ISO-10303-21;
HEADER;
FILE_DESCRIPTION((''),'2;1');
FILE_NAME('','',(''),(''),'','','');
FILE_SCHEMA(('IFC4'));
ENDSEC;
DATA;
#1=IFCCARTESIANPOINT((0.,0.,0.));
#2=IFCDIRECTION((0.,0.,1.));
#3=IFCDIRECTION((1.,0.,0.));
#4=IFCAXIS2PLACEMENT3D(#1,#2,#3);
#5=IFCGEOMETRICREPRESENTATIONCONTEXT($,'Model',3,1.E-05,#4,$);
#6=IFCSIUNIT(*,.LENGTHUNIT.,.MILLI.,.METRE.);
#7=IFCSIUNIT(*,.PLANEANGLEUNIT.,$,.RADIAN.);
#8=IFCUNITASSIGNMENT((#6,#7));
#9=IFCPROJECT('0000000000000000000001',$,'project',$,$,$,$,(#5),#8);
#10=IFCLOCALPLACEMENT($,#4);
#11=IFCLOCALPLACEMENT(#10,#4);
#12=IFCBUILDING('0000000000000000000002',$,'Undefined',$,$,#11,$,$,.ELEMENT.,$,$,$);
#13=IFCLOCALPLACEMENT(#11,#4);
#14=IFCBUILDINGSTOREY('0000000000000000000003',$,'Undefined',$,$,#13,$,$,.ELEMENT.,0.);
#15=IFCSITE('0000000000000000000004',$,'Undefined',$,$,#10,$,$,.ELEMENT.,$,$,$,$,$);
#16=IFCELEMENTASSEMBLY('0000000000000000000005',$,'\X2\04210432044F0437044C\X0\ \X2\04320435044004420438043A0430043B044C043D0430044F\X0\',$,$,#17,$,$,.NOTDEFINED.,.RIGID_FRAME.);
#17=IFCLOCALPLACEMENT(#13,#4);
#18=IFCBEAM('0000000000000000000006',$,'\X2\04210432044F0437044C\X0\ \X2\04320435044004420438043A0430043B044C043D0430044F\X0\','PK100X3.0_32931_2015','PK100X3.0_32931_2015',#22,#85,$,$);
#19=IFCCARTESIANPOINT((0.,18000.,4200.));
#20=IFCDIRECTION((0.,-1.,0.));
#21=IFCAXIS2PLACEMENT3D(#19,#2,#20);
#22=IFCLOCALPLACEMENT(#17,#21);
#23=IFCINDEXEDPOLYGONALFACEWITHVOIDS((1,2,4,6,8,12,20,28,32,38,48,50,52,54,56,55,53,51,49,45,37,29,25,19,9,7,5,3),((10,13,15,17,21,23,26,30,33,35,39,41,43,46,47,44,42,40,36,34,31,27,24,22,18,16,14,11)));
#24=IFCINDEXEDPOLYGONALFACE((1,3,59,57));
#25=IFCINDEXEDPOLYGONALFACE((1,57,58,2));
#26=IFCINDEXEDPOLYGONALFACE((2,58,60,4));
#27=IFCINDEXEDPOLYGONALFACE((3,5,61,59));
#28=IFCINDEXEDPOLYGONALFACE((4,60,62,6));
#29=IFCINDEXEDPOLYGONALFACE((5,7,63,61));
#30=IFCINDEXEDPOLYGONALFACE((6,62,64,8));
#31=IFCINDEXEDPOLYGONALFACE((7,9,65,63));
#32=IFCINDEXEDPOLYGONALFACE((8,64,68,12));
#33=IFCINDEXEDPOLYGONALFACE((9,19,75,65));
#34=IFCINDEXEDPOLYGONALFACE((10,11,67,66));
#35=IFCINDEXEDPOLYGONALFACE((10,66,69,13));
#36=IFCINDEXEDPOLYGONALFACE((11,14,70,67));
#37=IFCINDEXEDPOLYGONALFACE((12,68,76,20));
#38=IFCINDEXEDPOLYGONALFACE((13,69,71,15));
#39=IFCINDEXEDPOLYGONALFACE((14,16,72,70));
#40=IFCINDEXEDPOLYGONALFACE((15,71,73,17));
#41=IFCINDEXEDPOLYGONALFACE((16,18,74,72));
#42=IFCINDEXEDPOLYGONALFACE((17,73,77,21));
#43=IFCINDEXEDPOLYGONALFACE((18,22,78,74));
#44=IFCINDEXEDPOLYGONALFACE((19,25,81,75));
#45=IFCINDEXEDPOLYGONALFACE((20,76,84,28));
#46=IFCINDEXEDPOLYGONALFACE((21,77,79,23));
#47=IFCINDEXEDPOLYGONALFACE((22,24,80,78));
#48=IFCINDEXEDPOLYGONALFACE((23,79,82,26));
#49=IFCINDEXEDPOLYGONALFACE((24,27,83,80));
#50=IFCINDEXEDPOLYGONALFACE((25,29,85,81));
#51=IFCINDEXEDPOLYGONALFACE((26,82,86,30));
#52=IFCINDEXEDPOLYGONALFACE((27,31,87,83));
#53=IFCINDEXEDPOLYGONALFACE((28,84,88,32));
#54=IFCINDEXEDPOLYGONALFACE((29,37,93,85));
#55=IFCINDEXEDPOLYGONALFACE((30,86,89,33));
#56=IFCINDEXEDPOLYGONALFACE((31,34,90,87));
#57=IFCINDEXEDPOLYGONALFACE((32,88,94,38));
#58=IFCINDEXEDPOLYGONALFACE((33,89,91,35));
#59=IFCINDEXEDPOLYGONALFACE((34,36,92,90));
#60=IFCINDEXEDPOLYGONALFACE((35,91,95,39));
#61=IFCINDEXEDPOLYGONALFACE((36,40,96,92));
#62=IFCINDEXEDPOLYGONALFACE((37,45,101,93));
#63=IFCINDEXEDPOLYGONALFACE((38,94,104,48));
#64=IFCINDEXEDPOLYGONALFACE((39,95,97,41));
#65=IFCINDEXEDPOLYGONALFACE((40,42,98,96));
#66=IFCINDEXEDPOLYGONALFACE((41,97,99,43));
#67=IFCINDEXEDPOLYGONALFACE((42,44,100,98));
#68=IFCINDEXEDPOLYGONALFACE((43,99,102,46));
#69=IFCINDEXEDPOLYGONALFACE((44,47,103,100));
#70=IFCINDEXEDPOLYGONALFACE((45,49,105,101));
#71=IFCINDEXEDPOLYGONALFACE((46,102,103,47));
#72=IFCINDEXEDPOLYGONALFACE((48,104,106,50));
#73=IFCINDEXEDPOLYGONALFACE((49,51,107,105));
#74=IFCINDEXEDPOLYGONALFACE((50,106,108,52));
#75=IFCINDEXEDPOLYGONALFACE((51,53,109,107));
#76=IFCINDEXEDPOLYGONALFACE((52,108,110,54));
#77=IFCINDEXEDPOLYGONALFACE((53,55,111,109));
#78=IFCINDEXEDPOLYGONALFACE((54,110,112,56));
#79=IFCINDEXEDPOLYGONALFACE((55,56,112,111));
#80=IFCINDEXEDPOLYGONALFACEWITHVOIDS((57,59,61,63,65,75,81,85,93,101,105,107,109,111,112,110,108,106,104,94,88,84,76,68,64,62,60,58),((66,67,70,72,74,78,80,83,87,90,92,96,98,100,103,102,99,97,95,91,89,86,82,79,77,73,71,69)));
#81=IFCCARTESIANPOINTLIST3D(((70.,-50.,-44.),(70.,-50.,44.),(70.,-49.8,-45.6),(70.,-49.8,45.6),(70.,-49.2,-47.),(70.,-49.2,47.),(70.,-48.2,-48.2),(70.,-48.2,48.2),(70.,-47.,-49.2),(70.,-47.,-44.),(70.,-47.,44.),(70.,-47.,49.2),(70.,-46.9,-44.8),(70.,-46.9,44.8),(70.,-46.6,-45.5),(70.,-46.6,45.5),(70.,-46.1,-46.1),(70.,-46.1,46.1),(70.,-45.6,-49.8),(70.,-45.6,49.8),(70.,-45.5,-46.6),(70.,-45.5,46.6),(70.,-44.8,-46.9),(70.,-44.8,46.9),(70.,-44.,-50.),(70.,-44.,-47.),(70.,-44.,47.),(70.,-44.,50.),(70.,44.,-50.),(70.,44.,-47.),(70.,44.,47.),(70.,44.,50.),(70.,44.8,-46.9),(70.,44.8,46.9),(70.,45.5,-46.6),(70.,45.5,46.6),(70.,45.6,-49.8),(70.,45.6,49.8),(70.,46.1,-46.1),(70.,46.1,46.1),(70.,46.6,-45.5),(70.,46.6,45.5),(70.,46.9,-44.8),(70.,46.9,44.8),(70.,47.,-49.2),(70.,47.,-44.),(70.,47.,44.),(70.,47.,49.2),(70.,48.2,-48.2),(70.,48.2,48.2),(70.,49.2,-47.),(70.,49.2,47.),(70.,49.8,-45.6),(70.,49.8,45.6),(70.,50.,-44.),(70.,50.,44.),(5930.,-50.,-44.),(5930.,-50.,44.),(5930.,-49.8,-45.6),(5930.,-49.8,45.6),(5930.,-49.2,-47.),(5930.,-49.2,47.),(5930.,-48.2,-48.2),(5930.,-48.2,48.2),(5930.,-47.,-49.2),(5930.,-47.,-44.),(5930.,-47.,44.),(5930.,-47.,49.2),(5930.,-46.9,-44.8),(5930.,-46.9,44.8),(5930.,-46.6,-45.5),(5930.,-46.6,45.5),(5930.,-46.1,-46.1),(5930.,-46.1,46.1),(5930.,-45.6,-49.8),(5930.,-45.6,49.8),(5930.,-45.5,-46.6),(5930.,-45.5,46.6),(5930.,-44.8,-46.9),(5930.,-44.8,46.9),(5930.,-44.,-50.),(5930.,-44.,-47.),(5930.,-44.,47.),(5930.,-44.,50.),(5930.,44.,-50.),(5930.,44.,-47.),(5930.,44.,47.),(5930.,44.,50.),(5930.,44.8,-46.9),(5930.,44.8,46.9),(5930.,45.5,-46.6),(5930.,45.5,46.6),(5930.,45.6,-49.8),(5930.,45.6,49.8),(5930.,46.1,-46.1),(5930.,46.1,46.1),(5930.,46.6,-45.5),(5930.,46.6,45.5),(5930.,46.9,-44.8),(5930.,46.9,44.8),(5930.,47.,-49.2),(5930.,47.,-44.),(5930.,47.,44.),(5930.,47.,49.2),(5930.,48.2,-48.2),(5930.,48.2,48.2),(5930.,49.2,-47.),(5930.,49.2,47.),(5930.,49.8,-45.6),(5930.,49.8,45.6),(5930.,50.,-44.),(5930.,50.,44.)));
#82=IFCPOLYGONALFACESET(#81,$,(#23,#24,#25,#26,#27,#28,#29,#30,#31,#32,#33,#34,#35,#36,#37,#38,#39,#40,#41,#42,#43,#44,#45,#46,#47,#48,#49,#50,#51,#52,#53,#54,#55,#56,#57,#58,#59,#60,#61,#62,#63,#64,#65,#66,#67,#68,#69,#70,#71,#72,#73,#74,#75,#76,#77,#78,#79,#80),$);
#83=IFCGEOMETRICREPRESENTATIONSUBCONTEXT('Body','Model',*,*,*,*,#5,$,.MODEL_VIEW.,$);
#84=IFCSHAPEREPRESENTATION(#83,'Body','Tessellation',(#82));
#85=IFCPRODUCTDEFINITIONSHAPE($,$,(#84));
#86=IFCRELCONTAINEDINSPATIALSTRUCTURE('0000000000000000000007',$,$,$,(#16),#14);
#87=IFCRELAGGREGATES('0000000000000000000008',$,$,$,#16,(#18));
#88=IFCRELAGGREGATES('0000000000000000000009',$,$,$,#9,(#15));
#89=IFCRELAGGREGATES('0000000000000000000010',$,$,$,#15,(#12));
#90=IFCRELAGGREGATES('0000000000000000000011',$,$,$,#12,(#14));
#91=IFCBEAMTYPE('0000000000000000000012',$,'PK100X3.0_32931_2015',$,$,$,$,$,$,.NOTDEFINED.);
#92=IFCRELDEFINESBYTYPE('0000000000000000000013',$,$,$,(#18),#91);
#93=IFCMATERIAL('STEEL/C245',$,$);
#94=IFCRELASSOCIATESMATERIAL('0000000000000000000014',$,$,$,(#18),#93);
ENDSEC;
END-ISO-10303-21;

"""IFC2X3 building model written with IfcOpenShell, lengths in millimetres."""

from ifc_helpers import new_model, si_unit, frame, origin_with_axes, origin_2d_with_axis, place, context, subcontext, project, spatial, hollow_rectangle, extrude, clip, halfspace, material, type_object, element, aggregate, save


model = new_model("IFC2X3")

# Units and contexts
model_context = context("Model", 3, precision=1e-05, world=origin_with_axes())
body_context = subcontext(model_context, "Body", "Model", "MODEL_VIEW")
ifc_project = project(units=[si_unit("LENGTHUNIT", "METRE", prefix="MILLI"), si_unit("PLANEANGLEUNIT", "RADIAN")], contexts=[model_context])

# Site, building, storey
site_placement = place(None, origin_with_axes())
site = spatial("IfcSite", under=ifc_project, at=site_placement, Name="Undefined", CompositionType="ELEMENT")
building_placement = place(site_placement, origin_with_axes())
building = spatial("IfcBuilding", under=site, at=building_placement, Name="Undefined", CompositionType="ELEMENT")
storey_placement = place(building_placement, origin_with_axes())
storey = spatial("IfcBuildingStorey", under=building, at=storey_placement, Name="Undefined", CompositionType="ELEMENT", Elevation=0.0)

# Element assembly, beam
ifc_material_1 = material(Name="STEEL/C245")
beam_type_1 = type_object("IfcBeamType", Name="PK100X3.0_32931_2015", PredefinedType="NOTDEFINED")
assembly_1_placement = place(storey_placement, origin_with_axes())
assembly_1 = element("IfcElementAssembly", 1, at=assembly_1_placement, inside=storey, Name="Связь вертикальная", AssemblyPlace="NOTDEFINED", PredefinedType="RIGID_FRAME")
beam_1_placement = place(assembly_1_placement, frame((0.0, 18000.0, 4200.0), z_axis=(0.0, 0.0, 1.0), x_axis=(0.0, -1.0, 0.0)))
beam_1 = element("IfcBeam", 2, at=beam_1_placement, type_object=beam_type_1, material=ifc_material_1, Name="Связь вертикальная", Description="PK100X3.0_32931_2015", ObjectType="PK100X3.0_32931_2015", context=body_context, shape_type="Clipping", body=[
    clip(clip(extrude(hollow_rectangle(XDim=100.0, YDim=100.0, WallThickness=3.0, InnerFilletRadius=3.0, OuterFilletRadius=6.0, at=origin_2d_with_axis()), frame((5930.0, 0.0, 0.0), z_axis=(-1.0, 0.0, 0.0), x_axis=(0.0, -1.0, 0.0)), (0.0, 0.0, 1.0), 5860.0), halfspace(frame((5930.0, 0.0, -164.1), z_axis=(-1.0, 0.0, 0.0), x_axis=(0.0, 1.0, 0.0)), True)), halfspace(frame((70.0, 0.0, 380.8), z_axis=(-1.0, 0.0, 0.0), x_axis=(0.0, 1.0, 0.0)), False)),
])
aggregate(assembly_1, [beam_1])

save(model, "model.ifc")
